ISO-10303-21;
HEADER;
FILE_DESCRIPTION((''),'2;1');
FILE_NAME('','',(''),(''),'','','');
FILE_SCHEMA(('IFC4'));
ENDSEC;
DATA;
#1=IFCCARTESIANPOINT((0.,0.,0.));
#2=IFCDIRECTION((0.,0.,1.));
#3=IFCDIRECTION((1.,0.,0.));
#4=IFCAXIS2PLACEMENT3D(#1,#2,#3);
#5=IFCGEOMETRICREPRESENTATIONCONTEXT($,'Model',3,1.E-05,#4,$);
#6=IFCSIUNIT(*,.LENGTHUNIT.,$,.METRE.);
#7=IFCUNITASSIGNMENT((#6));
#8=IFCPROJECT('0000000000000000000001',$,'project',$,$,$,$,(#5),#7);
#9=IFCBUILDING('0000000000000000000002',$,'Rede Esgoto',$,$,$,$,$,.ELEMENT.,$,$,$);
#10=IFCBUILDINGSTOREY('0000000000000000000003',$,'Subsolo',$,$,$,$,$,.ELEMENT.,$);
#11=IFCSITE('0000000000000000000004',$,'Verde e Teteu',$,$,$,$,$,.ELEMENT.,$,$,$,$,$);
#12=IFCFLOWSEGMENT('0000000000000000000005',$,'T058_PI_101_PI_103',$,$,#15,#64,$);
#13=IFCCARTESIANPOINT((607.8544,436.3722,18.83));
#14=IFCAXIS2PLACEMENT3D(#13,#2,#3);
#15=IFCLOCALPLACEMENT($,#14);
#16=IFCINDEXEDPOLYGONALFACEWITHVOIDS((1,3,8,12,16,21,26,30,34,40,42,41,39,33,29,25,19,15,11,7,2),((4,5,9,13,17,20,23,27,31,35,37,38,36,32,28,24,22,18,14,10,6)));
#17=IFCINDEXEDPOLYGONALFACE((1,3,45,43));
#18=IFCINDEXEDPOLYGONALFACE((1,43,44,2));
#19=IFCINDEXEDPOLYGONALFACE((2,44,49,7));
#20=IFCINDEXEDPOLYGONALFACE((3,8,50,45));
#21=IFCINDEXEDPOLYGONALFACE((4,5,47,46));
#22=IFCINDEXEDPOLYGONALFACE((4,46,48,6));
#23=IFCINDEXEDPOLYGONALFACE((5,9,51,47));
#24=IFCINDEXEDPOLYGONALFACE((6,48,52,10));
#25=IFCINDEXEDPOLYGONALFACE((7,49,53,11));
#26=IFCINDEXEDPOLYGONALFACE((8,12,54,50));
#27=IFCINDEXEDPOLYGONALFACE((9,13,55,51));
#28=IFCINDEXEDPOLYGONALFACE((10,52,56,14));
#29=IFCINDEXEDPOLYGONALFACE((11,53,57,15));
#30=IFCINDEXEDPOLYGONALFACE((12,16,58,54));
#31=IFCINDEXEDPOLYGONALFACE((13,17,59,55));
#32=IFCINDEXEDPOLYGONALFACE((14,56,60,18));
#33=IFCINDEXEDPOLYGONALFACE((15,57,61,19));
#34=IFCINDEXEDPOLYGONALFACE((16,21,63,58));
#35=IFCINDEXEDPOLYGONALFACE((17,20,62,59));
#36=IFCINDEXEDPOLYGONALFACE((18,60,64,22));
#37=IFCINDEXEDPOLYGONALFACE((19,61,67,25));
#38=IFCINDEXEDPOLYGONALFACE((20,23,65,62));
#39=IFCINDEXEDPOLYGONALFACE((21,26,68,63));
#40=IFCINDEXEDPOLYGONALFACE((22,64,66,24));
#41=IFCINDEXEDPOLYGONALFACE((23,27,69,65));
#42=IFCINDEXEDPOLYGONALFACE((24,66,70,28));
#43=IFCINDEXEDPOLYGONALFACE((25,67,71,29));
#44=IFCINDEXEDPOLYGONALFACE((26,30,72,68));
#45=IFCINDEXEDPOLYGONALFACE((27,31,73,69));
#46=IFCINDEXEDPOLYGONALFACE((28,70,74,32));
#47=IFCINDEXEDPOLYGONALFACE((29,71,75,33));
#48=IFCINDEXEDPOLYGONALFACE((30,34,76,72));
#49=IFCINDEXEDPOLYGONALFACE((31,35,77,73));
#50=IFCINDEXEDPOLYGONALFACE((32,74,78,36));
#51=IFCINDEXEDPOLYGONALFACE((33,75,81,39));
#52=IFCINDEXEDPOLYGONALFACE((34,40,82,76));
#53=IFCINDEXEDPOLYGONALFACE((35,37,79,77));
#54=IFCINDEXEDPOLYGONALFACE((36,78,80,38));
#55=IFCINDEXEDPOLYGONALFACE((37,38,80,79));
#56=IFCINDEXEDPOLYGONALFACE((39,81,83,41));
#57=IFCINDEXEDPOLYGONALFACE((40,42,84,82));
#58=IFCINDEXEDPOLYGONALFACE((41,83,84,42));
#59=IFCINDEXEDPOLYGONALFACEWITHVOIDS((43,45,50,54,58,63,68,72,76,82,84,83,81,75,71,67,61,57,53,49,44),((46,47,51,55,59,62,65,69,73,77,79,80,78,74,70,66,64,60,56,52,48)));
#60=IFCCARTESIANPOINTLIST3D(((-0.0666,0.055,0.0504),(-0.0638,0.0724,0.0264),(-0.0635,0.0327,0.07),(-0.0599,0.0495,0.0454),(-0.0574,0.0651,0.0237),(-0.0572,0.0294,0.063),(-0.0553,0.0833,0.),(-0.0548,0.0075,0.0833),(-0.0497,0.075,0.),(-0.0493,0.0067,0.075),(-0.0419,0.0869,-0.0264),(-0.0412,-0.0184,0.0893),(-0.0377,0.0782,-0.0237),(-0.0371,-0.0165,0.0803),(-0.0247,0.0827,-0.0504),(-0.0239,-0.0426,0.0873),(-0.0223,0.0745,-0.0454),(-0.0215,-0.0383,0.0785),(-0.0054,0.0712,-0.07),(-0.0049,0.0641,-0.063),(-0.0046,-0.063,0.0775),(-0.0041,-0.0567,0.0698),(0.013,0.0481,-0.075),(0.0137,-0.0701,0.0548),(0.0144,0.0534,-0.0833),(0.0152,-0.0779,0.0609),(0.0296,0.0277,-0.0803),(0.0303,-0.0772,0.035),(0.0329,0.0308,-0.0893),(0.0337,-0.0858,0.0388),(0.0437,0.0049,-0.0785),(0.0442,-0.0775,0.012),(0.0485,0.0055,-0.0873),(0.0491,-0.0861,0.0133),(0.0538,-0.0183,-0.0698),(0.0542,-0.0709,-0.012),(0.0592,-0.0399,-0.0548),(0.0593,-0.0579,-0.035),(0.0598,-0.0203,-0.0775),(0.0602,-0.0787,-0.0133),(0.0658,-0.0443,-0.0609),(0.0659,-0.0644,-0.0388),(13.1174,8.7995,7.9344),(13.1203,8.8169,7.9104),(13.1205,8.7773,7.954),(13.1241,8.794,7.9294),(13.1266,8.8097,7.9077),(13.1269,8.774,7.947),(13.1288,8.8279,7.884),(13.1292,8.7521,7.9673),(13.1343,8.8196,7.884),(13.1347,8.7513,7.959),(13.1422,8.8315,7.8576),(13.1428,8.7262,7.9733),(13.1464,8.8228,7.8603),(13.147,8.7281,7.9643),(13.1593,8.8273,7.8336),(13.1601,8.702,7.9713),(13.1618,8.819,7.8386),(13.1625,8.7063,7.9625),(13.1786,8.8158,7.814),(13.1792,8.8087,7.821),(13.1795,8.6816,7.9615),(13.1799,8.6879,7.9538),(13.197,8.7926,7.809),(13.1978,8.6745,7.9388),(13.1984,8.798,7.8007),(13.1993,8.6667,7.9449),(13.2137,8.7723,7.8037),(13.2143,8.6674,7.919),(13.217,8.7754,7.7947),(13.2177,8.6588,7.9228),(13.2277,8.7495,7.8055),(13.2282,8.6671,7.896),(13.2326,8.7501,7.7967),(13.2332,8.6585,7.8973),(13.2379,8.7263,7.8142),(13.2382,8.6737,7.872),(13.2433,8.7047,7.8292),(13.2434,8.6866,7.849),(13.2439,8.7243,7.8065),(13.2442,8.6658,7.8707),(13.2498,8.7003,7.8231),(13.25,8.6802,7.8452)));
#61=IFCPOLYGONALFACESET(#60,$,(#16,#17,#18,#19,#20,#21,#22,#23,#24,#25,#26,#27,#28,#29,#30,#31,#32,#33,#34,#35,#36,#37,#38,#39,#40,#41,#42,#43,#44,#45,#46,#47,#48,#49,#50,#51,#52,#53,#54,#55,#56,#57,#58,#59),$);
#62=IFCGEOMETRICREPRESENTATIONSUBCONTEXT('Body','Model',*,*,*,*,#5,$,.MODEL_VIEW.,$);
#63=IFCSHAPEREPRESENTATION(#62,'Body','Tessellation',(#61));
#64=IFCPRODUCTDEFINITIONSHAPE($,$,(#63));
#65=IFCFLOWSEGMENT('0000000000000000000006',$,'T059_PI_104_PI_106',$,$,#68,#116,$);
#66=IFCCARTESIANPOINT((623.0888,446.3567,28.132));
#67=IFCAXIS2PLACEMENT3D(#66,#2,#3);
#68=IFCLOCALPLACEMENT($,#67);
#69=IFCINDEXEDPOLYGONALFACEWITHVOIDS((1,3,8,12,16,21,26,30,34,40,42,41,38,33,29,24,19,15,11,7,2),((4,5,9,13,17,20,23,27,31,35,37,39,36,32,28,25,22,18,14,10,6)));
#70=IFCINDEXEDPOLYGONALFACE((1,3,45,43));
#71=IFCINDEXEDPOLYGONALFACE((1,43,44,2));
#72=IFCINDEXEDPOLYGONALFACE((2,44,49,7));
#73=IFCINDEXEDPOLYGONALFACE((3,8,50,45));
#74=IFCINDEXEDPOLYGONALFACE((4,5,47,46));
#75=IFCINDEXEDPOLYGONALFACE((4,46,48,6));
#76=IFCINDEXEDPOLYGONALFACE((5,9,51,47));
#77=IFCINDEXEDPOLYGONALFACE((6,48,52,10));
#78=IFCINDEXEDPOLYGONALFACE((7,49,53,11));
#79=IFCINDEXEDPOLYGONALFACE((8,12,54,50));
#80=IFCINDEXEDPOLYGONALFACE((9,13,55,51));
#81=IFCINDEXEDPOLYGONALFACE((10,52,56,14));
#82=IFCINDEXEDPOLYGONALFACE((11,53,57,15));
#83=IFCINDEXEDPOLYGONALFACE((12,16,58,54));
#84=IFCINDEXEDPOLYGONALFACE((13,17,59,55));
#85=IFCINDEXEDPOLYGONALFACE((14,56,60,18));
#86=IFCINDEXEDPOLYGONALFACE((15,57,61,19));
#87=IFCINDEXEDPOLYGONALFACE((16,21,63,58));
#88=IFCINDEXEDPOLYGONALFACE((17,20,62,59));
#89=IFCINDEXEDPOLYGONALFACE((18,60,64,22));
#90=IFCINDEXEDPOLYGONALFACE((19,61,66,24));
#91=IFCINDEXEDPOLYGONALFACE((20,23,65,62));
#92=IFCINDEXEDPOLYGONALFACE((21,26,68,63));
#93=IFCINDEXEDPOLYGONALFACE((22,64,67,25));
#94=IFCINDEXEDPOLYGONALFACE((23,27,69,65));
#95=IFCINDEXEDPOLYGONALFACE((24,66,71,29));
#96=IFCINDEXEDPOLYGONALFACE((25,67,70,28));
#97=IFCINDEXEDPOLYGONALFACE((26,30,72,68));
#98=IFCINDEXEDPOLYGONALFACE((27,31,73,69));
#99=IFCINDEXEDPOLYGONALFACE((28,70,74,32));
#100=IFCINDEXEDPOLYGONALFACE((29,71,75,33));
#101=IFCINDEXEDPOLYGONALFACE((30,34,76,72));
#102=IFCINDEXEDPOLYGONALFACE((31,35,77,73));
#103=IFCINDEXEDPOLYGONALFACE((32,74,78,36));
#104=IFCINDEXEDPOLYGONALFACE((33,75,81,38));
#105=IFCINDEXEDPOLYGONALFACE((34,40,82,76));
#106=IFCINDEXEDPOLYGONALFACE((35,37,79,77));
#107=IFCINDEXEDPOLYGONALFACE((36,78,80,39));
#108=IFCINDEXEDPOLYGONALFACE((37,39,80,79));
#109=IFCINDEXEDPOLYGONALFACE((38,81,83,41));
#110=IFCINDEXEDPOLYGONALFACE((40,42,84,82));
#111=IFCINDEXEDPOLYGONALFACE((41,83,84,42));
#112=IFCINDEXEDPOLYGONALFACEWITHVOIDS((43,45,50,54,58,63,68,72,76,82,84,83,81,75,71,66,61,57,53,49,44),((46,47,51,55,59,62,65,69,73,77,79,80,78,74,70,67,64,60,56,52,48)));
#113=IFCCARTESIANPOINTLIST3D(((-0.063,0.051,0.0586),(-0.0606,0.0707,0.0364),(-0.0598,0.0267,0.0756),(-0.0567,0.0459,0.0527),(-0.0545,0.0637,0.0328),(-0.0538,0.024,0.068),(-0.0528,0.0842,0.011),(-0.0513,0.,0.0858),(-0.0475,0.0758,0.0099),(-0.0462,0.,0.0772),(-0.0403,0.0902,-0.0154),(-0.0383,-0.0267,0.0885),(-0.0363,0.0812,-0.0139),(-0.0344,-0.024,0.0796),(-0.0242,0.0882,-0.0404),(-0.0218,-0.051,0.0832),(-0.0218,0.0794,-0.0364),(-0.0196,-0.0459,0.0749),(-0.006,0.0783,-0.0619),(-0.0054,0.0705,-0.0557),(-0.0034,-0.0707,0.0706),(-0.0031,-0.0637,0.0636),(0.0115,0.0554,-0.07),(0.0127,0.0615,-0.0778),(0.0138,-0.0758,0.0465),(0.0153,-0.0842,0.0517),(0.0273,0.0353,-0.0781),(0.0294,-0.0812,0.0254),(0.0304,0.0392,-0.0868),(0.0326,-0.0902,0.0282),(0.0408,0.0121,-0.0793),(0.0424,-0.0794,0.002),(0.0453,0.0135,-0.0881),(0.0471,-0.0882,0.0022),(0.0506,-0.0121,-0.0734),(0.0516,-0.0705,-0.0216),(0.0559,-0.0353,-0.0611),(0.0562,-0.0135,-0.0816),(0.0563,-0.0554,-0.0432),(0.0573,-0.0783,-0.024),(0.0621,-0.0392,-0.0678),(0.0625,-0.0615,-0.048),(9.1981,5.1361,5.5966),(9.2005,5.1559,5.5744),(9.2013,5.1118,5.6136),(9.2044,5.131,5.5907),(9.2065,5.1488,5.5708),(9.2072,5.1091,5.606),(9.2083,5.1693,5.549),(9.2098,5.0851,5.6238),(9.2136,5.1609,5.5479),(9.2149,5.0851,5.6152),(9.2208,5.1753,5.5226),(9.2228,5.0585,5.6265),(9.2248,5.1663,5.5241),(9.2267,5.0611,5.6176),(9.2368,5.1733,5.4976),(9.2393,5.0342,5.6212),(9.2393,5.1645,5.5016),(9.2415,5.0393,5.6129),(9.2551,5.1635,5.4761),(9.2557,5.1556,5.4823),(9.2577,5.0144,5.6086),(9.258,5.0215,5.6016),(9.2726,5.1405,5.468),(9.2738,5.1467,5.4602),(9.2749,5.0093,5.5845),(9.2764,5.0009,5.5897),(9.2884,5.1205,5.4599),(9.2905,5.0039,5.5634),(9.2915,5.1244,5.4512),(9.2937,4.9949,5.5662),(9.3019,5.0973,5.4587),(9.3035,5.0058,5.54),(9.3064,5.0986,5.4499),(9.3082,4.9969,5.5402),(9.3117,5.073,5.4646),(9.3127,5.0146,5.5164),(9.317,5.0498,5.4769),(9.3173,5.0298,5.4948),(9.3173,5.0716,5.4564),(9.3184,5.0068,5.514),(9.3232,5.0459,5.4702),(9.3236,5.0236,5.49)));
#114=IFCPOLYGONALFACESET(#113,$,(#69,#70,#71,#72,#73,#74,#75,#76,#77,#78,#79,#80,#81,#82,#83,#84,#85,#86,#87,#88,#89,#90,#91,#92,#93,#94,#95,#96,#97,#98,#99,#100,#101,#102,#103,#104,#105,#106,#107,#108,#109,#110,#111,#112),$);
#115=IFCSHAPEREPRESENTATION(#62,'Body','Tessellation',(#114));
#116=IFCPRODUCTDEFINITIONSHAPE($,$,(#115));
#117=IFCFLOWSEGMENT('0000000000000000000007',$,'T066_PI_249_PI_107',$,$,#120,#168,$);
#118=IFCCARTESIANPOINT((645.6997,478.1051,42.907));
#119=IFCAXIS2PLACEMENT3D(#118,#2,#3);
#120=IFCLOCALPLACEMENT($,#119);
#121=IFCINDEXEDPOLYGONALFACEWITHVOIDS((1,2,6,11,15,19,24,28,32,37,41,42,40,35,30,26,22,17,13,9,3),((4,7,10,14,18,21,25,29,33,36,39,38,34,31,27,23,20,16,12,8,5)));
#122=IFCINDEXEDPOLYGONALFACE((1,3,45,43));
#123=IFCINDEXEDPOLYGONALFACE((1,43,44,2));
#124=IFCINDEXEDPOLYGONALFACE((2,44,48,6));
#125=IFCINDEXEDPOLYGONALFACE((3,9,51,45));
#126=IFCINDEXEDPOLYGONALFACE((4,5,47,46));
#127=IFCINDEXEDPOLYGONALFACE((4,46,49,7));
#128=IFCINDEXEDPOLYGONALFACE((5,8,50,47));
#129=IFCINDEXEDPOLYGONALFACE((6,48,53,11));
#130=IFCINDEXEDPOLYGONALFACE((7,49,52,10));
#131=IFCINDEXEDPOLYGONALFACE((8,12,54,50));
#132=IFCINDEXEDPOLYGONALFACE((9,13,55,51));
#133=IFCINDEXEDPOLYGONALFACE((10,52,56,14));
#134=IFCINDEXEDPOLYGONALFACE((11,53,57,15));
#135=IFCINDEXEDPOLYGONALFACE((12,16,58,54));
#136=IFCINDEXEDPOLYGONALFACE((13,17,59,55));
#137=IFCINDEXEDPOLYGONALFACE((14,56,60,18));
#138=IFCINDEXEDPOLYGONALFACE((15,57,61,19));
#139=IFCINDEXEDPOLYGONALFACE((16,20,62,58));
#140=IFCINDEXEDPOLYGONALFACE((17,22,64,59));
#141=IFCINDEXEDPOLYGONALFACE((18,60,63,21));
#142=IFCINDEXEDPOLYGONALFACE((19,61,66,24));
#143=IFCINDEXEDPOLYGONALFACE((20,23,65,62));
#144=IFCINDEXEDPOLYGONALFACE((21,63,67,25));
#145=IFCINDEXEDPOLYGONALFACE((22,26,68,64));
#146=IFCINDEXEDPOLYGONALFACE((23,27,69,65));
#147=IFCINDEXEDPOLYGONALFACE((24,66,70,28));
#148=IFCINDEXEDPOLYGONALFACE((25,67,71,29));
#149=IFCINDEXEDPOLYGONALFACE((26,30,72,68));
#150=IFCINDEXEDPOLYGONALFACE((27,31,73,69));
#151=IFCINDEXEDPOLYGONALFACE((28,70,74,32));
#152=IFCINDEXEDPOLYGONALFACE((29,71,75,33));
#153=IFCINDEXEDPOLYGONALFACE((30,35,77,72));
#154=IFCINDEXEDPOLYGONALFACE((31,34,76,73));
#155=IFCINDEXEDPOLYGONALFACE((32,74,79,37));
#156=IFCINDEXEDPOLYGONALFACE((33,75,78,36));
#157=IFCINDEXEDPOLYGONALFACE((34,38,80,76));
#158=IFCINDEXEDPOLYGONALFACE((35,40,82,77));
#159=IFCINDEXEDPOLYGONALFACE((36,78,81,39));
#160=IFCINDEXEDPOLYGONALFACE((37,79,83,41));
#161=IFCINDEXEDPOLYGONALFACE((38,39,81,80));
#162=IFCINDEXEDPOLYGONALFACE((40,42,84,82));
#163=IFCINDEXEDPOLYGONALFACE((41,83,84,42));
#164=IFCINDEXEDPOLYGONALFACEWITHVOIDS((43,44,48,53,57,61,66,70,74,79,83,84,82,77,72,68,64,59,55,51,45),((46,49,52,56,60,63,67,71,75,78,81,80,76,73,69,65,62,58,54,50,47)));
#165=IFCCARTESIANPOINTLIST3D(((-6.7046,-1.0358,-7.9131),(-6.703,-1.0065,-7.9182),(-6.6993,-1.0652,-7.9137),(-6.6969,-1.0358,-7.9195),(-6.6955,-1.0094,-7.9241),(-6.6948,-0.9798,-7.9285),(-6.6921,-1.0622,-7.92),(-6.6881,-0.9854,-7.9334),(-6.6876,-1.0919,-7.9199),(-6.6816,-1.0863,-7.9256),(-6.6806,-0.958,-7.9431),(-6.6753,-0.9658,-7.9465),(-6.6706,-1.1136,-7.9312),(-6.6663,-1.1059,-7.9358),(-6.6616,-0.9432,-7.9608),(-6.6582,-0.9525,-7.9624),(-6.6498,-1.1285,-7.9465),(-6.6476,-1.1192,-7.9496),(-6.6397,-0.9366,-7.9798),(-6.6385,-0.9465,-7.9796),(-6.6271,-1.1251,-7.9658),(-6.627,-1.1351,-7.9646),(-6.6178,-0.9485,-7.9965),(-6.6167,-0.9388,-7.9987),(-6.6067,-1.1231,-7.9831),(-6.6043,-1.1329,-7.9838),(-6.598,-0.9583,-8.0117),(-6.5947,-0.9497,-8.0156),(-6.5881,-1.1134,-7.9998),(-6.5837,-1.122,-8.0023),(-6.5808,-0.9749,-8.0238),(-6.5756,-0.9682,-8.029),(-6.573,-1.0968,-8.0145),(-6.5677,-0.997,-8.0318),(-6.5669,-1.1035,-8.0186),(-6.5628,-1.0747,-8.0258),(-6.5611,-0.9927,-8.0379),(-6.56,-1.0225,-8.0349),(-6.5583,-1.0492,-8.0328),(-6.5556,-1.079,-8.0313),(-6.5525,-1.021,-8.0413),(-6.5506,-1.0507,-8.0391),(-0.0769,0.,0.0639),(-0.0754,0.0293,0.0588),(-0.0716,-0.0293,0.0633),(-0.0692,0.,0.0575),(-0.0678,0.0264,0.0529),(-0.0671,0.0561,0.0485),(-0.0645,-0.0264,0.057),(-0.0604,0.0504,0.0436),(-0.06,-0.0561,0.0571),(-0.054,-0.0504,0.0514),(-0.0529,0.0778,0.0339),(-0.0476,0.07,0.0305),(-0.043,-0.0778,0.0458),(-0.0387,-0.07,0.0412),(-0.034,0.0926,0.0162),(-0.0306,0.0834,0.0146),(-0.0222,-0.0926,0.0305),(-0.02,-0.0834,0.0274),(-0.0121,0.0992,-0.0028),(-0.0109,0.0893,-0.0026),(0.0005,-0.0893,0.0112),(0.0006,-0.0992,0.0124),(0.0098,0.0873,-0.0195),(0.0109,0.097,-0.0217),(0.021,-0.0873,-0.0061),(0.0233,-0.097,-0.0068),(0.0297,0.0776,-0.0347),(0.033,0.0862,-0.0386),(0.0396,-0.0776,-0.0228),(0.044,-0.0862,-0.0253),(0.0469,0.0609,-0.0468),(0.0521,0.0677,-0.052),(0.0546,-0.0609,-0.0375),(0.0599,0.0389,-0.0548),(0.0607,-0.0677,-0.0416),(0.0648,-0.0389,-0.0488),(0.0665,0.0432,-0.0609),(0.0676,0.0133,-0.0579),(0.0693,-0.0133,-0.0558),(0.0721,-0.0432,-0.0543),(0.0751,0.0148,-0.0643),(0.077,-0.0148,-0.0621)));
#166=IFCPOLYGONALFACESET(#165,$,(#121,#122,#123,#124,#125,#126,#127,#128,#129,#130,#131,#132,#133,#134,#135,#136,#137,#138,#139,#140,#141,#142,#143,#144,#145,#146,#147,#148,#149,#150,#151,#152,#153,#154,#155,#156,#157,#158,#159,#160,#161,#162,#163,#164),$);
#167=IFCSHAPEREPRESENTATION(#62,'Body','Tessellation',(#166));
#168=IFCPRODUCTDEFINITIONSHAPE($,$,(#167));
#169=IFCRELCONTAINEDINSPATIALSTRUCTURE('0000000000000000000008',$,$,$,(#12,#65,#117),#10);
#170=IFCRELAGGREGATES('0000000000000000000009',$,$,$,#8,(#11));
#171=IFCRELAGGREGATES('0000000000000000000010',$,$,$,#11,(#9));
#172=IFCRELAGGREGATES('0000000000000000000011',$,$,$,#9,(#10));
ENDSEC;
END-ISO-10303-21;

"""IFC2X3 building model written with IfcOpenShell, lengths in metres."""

from ifc_helpers import new_model, entity, si_unit, frame, origin_with_axes, place, context, subcontext, project, spatial, element, save


model = new_model("IFC2X3")

# Units and contexts
model_context = context("Model", 3, precision=1e-05, world=origin_with_axes())
body_context = subcontext(model_context, "Body", "Model", "MODEL_VIEW")
ifc_project = project(units=[si_unit("LENGTHUNIT", "METRE")], contexts=[model_context])

# Site, building, storey
site = spatial("IfcSite", under=ifc_project, Name="Verde e Teteu", CompositionType="ELEMENT")
building = spatial("IfcBuilding", under=site, Name="Rede Esgoto", CompositionType="ELEMENT")
storey = spatial("IfcBuildingStorey", under=building, Name="Subsolo", CompositionType="ELEMENT")

# Flow segments
flow_segment_1_placement = place(None, frame((607.8544, 436.3722, 18.83), z_axis=(0.0, 0.0, 1.0), x_axis=(1.0, 0.0, 0.0)))
element("IfcFlowSegment", 1, at=flow_segment_1_placement, inside=storey, Name="T058_PI_101_PI_103", context=body_context, shape_type="SweptSolid", body=[
    entity("IfcSweptDiskSolid", entity("IfcPolyline", [entity("IfcCartesianPoint", [0.0, 0.0, 0.0]), entity("IfcCartesianPoint", [13.184, 8.7446, 7.884])]), 0.1, 0.09),
])
flow_segment_2_placement = place(None, frame((623.0888, 446.3567, 28.132), z_axis=(0.0, 0.0, 1.0), x_axis=(1.0, 0.0, 0.0)))
element("IfcFlowSegment", 2, at=flow_segment_2_placement, inside=storey, Name="T059_PI_104_PI_106", context=body_context, shape_type="SweptSolid", body=[
    entity("IfcSweptDiskSolid", entity("IfcPolyline", [entity("IfcCartesianPoint", [0.0, 0.0, 0.0]), entity("IfcCartesianPoint", [9.2611, 5.0851, 5.538])]), 0.1, 0.09),
])
flow_segment_3_placement = place(None, frame((645.6997, 478.1051, 42.907), z_axis=(0.0, 0.0, 1.0), x_axis=(1.0, 0.0, 0.0)))
element("IfcFlowSegment", 3, at=flow_segment_3_placement, inside=storey, Name="T066_PI_249_PI_107", context=body_context, shape_type="SweptSolid", body=[
    entity("IfcSweptDiskSolid", entity("IfcPolyline", [entity("IfcCartesianPoint", [0.0, 0.0, 0.0]), entity("IfcCartesianPoint", [-6.6276, -1.0358, -7.977])]), 0.1, 0.09),
])

save(model, "model.ifc")
